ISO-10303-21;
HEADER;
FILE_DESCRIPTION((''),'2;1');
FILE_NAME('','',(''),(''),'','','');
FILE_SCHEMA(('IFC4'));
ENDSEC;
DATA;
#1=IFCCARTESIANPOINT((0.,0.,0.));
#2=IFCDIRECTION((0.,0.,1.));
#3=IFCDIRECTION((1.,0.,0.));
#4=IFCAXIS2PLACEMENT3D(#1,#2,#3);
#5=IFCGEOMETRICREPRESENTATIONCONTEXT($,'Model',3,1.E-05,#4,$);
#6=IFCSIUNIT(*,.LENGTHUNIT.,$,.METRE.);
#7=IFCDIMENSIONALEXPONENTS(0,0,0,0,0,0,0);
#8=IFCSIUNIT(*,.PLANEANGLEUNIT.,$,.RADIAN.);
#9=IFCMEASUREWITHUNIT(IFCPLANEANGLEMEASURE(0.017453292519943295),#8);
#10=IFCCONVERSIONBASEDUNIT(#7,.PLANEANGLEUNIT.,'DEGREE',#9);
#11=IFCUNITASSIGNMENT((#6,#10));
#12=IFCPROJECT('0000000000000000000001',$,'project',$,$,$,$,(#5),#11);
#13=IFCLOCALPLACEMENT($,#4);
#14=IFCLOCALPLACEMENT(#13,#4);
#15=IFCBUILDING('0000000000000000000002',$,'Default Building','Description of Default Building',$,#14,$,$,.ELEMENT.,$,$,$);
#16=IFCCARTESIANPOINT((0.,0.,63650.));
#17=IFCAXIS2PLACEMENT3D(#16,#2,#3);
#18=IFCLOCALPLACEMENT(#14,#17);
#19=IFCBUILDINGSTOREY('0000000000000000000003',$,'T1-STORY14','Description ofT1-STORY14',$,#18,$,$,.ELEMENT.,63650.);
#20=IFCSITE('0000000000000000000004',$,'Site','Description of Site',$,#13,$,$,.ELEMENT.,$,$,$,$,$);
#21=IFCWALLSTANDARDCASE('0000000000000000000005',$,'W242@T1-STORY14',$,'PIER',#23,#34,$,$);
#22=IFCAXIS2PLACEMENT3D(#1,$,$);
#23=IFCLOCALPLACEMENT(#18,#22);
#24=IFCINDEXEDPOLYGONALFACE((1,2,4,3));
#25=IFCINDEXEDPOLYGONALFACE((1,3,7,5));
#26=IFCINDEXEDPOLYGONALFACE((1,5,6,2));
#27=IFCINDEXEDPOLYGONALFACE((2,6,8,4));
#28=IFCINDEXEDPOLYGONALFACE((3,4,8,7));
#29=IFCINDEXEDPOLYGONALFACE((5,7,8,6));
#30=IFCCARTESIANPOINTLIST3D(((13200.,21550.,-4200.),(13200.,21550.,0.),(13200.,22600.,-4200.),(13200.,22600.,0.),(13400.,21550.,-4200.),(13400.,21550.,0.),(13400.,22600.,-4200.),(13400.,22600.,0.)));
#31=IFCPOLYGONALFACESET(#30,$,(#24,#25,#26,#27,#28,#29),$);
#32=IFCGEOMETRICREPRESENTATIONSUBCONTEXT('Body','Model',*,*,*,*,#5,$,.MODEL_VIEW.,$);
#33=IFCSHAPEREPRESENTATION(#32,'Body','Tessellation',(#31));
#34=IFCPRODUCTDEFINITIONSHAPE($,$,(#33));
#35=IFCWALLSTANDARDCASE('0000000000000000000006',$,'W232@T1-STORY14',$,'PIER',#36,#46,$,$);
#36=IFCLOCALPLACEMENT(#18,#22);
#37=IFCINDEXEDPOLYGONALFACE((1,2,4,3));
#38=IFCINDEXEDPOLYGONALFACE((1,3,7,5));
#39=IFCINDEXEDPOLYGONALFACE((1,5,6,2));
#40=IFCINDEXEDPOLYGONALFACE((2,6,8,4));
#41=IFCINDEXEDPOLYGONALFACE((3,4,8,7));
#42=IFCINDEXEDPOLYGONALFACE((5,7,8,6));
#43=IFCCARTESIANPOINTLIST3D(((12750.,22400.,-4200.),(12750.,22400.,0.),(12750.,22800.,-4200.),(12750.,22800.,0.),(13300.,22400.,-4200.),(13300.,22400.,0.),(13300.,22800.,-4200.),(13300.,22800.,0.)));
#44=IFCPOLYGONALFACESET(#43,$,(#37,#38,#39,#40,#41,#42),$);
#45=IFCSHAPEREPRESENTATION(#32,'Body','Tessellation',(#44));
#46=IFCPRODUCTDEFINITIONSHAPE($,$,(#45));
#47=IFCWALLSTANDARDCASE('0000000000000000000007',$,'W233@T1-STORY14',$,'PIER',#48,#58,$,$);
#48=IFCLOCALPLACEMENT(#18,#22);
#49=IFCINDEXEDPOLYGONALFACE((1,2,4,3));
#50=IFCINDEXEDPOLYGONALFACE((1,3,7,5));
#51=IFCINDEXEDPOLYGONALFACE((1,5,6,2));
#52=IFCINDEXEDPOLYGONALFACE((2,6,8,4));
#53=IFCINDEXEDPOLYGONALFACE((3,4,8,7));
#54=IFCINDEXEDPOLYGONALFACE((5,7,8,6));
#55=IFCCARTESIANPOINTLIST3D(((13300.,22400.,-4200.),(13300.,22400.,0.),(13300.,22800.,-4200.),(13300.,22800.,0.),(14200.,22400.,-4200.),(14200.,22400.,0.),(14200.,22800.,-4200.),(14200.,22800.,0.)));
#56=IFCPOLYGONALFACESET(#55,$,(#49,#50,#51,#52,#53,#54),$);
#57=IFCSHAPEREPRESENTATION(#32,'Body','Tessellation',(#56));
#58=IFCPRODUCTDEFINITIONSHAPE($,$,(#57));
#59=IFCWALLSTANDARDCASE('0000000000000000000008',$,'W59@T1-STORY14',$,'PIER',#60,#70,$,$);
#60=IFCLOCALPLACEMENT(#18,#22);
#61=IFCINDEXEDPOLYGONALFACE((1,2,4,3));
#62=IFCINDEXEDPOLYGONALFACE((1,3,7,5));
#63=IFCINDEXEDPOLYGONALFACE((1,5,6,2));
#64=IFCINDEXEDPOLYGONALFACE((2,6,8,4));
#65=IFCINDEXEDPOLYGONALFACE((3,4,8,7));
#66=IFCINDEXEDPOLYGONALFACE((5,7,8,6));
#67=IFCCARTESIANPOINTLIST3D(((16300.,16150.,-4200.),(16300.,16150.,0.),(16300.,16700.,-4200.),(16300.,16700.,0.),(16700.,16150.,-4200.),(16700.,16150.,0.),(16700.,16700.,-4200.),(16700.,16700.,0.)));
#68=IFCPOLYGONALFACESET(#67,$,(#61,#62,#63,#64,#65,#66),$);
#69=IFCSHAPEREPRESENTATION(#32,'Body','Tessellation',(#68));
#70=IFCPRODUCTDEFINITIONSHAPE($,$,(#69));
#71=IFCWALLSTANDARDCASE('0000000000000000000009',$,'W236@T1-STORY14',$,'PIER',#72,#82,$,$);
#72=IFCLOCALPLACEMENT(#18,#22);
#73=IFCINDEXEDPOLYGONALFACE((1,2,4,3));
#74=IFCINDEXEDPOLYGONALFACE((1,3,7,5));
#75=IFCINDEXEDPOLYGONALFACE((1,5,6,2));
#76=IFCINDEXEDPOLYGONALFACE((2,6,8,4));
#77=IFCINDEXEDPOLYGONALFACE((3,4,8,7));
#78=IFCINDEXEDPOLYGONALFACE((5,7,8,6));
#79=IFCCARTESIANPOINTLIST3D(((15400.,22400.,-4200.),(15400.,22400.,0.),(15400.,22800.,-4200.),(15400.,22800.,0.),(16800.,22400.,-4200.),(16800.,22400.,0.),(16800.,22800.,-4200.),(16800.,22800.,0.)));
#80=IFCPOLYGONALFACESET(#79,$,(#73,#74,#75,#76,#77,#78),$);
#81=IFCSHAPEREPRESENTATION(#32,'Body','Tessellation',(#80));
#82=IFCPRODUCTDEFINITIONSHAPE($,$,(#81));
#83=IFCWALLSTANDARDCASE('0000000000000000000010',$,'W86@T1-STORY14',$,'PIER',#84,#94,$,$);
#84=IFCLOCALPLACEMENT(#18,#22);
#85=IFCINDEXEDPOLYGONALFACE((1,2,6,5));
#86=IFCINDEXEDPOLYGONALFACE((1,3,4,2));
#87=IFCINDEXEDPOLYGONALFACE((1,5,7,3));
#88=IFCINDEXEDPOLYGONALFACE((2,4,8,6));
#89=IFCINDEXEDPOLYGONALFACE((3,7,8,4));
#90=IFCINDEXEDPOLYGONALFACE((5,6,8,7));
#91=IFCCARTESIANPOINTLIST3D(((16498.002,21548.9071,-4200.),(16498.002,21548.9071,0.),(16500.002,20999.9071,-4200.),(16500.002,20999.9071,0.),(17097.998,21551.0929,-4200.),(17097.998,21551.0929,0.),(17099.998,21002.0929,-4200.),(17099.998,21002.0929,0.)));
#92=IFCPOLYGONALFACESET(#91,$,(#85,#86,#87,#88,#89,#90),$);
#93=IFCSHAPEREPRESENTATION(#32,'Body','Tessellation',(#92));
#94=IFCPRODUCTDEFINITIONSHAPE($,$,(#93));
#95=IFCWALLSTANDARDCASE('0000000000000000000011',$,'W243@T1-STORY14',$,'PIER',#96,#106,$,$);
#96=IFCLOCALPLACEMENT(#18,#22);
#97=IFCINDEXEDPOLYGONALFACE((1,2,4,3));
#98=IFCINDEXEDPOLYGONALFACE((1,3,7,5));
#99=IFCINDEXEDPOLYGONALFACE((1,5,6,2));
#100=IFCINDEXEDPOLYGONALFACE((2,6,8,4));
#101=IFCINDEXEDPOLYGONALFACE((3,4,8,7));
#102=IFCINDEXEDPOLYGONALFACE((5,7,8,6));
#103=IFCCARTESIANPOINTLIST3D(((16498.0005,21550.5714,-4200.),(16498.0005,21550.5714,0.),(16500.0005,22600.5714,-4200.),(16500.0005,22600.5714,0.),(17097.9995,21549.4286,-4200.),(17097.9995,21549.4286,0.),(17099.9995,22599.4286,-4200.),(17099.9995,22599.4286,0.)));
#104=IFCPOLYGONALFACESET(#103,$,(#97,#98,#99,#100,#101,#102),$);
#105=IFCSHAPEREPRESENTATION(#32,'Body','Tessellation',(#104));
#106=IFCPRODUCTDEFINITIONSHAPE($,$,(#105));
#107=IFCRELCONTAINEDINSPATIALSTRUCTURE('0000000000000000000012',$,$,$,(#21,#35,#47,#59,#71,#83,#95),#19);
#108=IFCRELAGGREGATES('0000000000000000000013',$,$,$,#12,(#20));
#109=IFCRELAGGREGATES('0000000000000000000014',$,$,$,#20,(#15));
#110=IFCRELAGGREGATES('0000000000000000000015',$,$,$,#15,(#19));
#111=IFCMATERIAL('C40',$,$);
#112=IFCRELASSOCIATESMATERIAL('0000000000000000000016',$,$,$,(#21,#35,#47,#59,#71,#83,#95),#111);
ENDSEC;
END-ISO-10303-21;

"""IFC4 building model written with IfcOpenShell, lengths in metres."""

from ifc_helpers import new_model, entity, si_unit, converted_unit, frame, origin_with_axes, place, context, subcontext, project, spatial, indexed_curve, outline, extrude, material, element, save


model = new_model("IFC4")

# Units and contexts
model_context = context("Model", 3, precision=1e-05, world=origin_with_axes())
body_context = subcontext(model_context, "Body", "Model", "MODEL_VIEW")
ifc_project = project(units=[si_unit("LENGTHUNIT", "METRE"), converted_unit("PLANEANGLEUNIT", "DEGREE", entity("IfcPlaneAngleMeasure", 0.017453292519943295), si_unit("PLANEANGLEUNIT", "RADIAN"), dimensions=[0, 0, 0, 0, 0, 0, 0])], contexts=[model_context])

# Site, building, storey
site_placement = place(None, origin_with_axes())
site = spatial("IfcSite", under=ifc_project, at=site_placement, Name="Site", Description="Description of Site", CompositionType="ELEMENT")
building_placement = place(site_placement, origin_with_axes())
building = spatial("IfcBuilding", under=site, at=building_placement, Name="Default Building", Description="Description of Default Building", CompositionType="ELEMENT")
storey_placement = place(building_placement, frame((0.0, 0.0, 63650.0), z_axis=(0.0, 0.0, 1.0), x_axis=(1.0, 0.0, 0.0)))
storey = spatial("IfcBuildingStorey", under=building, at=storey_placement, Name="T1-STORY14", Description="Description ofT1-STORY14", CompositionType="ELEMENT", Elevation=63650.0)

# Walls
ifc_material_1 = material(Name="C40")
wall_1_placement = place(storey_placement, frame((13300.0, 21550.0, -4200.0), z_axis=(0.0, 0.0, 1.0), x_axis=(0.0, 1.0, 0.0)))
element("IfcWallStandardCase", 1, at=wall_1_placement, inside=storey, material=ifc_material_1, Name="W242@T1-STORY14", ObjectType="PIER", context=body_context, shape_type="SweptSolid", body=[
    extrude(outline(indexed_curve([(0.0, -100.0), (0.0, 100.0), (1050.0, 100.0), (1050.0, -100.0), (0.0, -100.0)], self_intersect=False)), origin_with_axes(), (0.0, 0.0, 1.0), 4200.0),
])
wall_2_placement = place(storey_placement, frame((12750.0, 22600.0, -4200.0), z_axis=(0.0, 0.0, 1.0), x_axis=(1.0, 0.0, 0.0)))
element("IfcWallStandardCase", 2, at=wall_2_placement, inside=storey, material=ifc_material_1, Name="W232@T1-STORY14", ObjectType="PIER", context=body_context, shape_type="SweptSolid", body=[
    extrude(outline(indexed_curve([(0.0, -200.0), (0.0, 200.0), (550.0, 200.0), (550.0, -200.0), (0.0, -200.0)], self_intersect=False)), origin_with_axes(), (0.0, 0.0, 1.0), 4200.0),
])
wall_3_placement = place(storey_placement, frame((13300.0, 22600.0, -4200.0), z_axis=(0.0, 0.0, 1.0), x_axis=(1.0, 0.0, 0.0)))
element("IfcWallStandardCase", 3, at=wall_3_placement, inside=storey, material=ifc_material_1, Name="W233@T1-STORY14", ObjectType="PIER", context=body_context, shape_type="SweptSolid", body=[
    extrude(outline(indexed_curve([(0.0, -200.0), (0.0, 200.0), (900.0, 200.0), (900.0, -200.0), (0.0, -200.0)], self_intersect=False)), origin_with_axes(), (0.0, 0.0, 1.0), 4200.0),
])
wall_4_placement = place(storey_placement, frame((16500.0, 16150.0, -4200.0), z_axis=(0.0, 0.0, 1.0), x_axis=(0.0, 1.0, 0.0)))
element("IfcWallStandardCase", 4, at=wall_4_placement, inside=storey, material=ifc_material_1, Name="W59@T1-STORY14", ObjectType="PIER", context=body_context, shape_type="SweptSolid", body=[
    extrude(outline(indexed_curve([(0.0, -200.0), (0.0, 200.0), (550.0, 200.0), (550.0, -200.0), (0.0, -200.0)], self_intersect=False)), origin_with_axes(), (0.0, 0.0, 1.0), 4200.0),
])
wall_5_placement = place(storey_placement, frame((15400.0, 22600.0, -4200.0), z_axis=(0.0, 0.0, 1.0), x_axis=(1.0, 0.0, 0.0)))
element("IfcWallStandardCase", 5, at=wall_5_placement, inside=storey, material=ifc_material_1, Name="W236@T1-STORY14", ObjectType="PIER", context=body_context, shape_type="SweptSolid", body=[
    extrude(outline(indexed_curve([(0.0, -200.0), (0.0, 200.0), (1400.0, 200.0), (1400.0, -200.0), (0.0, -200.0)], self_intersect=False)), origin_with_axes(), (0.0, 0.0, 1.0), 4200.0),
])
wall_6_placement = place(storey_placement, frame((16800.0, 21001.0, -4200.0), z_axis=(0.0, 0.0, 1.0), x_axis=(-0.003643, 0.999993, 0.0)))
element("IfcWallStandardCase", 6, at=wall_6_placement, inside=storey, material=ifc_material_1, Name="W86@T1-STORY14", ObjectType="PIER", context=body_context, shape_type="SweptSolid", body=[
    extrude(outline(indexed_curve([(0.0, -300.0), (0.0, 300.0), (549.0036, 300.0), (549.0036, -300.0), (0.0, -300.0)], self_intersect=False)), origin_with_axes(), (0.0, 0.0, 1.0), 4200.0),
])
wall_7_placement = place(storey_placement, frame((16798.0, 21550.0, -4200.0), z_axis=(0.0, 0.0, 1.0), x_axis=(0.001905, 0.999998, 0.0)))
element("IfcWallStandardCase", 7, at=wall_7_placement, inside=storey, material=ifc_material_1, Name="W243@T1-STORY14", ObjectType="PIER", context=body_context, shape_type="SweptSolid", body=[
    extrude(outline(indexed_curve([(0.0, -300.0), (0.0, 300.0), (1050.0019, 300.0), (1050.0019, -300.0), (0.0, -300.0)], self_intersect=False)), origin_with_axes(), (0.0, 0.0, 1.0), 4200.0),
])

save(model, "model.ifc")
